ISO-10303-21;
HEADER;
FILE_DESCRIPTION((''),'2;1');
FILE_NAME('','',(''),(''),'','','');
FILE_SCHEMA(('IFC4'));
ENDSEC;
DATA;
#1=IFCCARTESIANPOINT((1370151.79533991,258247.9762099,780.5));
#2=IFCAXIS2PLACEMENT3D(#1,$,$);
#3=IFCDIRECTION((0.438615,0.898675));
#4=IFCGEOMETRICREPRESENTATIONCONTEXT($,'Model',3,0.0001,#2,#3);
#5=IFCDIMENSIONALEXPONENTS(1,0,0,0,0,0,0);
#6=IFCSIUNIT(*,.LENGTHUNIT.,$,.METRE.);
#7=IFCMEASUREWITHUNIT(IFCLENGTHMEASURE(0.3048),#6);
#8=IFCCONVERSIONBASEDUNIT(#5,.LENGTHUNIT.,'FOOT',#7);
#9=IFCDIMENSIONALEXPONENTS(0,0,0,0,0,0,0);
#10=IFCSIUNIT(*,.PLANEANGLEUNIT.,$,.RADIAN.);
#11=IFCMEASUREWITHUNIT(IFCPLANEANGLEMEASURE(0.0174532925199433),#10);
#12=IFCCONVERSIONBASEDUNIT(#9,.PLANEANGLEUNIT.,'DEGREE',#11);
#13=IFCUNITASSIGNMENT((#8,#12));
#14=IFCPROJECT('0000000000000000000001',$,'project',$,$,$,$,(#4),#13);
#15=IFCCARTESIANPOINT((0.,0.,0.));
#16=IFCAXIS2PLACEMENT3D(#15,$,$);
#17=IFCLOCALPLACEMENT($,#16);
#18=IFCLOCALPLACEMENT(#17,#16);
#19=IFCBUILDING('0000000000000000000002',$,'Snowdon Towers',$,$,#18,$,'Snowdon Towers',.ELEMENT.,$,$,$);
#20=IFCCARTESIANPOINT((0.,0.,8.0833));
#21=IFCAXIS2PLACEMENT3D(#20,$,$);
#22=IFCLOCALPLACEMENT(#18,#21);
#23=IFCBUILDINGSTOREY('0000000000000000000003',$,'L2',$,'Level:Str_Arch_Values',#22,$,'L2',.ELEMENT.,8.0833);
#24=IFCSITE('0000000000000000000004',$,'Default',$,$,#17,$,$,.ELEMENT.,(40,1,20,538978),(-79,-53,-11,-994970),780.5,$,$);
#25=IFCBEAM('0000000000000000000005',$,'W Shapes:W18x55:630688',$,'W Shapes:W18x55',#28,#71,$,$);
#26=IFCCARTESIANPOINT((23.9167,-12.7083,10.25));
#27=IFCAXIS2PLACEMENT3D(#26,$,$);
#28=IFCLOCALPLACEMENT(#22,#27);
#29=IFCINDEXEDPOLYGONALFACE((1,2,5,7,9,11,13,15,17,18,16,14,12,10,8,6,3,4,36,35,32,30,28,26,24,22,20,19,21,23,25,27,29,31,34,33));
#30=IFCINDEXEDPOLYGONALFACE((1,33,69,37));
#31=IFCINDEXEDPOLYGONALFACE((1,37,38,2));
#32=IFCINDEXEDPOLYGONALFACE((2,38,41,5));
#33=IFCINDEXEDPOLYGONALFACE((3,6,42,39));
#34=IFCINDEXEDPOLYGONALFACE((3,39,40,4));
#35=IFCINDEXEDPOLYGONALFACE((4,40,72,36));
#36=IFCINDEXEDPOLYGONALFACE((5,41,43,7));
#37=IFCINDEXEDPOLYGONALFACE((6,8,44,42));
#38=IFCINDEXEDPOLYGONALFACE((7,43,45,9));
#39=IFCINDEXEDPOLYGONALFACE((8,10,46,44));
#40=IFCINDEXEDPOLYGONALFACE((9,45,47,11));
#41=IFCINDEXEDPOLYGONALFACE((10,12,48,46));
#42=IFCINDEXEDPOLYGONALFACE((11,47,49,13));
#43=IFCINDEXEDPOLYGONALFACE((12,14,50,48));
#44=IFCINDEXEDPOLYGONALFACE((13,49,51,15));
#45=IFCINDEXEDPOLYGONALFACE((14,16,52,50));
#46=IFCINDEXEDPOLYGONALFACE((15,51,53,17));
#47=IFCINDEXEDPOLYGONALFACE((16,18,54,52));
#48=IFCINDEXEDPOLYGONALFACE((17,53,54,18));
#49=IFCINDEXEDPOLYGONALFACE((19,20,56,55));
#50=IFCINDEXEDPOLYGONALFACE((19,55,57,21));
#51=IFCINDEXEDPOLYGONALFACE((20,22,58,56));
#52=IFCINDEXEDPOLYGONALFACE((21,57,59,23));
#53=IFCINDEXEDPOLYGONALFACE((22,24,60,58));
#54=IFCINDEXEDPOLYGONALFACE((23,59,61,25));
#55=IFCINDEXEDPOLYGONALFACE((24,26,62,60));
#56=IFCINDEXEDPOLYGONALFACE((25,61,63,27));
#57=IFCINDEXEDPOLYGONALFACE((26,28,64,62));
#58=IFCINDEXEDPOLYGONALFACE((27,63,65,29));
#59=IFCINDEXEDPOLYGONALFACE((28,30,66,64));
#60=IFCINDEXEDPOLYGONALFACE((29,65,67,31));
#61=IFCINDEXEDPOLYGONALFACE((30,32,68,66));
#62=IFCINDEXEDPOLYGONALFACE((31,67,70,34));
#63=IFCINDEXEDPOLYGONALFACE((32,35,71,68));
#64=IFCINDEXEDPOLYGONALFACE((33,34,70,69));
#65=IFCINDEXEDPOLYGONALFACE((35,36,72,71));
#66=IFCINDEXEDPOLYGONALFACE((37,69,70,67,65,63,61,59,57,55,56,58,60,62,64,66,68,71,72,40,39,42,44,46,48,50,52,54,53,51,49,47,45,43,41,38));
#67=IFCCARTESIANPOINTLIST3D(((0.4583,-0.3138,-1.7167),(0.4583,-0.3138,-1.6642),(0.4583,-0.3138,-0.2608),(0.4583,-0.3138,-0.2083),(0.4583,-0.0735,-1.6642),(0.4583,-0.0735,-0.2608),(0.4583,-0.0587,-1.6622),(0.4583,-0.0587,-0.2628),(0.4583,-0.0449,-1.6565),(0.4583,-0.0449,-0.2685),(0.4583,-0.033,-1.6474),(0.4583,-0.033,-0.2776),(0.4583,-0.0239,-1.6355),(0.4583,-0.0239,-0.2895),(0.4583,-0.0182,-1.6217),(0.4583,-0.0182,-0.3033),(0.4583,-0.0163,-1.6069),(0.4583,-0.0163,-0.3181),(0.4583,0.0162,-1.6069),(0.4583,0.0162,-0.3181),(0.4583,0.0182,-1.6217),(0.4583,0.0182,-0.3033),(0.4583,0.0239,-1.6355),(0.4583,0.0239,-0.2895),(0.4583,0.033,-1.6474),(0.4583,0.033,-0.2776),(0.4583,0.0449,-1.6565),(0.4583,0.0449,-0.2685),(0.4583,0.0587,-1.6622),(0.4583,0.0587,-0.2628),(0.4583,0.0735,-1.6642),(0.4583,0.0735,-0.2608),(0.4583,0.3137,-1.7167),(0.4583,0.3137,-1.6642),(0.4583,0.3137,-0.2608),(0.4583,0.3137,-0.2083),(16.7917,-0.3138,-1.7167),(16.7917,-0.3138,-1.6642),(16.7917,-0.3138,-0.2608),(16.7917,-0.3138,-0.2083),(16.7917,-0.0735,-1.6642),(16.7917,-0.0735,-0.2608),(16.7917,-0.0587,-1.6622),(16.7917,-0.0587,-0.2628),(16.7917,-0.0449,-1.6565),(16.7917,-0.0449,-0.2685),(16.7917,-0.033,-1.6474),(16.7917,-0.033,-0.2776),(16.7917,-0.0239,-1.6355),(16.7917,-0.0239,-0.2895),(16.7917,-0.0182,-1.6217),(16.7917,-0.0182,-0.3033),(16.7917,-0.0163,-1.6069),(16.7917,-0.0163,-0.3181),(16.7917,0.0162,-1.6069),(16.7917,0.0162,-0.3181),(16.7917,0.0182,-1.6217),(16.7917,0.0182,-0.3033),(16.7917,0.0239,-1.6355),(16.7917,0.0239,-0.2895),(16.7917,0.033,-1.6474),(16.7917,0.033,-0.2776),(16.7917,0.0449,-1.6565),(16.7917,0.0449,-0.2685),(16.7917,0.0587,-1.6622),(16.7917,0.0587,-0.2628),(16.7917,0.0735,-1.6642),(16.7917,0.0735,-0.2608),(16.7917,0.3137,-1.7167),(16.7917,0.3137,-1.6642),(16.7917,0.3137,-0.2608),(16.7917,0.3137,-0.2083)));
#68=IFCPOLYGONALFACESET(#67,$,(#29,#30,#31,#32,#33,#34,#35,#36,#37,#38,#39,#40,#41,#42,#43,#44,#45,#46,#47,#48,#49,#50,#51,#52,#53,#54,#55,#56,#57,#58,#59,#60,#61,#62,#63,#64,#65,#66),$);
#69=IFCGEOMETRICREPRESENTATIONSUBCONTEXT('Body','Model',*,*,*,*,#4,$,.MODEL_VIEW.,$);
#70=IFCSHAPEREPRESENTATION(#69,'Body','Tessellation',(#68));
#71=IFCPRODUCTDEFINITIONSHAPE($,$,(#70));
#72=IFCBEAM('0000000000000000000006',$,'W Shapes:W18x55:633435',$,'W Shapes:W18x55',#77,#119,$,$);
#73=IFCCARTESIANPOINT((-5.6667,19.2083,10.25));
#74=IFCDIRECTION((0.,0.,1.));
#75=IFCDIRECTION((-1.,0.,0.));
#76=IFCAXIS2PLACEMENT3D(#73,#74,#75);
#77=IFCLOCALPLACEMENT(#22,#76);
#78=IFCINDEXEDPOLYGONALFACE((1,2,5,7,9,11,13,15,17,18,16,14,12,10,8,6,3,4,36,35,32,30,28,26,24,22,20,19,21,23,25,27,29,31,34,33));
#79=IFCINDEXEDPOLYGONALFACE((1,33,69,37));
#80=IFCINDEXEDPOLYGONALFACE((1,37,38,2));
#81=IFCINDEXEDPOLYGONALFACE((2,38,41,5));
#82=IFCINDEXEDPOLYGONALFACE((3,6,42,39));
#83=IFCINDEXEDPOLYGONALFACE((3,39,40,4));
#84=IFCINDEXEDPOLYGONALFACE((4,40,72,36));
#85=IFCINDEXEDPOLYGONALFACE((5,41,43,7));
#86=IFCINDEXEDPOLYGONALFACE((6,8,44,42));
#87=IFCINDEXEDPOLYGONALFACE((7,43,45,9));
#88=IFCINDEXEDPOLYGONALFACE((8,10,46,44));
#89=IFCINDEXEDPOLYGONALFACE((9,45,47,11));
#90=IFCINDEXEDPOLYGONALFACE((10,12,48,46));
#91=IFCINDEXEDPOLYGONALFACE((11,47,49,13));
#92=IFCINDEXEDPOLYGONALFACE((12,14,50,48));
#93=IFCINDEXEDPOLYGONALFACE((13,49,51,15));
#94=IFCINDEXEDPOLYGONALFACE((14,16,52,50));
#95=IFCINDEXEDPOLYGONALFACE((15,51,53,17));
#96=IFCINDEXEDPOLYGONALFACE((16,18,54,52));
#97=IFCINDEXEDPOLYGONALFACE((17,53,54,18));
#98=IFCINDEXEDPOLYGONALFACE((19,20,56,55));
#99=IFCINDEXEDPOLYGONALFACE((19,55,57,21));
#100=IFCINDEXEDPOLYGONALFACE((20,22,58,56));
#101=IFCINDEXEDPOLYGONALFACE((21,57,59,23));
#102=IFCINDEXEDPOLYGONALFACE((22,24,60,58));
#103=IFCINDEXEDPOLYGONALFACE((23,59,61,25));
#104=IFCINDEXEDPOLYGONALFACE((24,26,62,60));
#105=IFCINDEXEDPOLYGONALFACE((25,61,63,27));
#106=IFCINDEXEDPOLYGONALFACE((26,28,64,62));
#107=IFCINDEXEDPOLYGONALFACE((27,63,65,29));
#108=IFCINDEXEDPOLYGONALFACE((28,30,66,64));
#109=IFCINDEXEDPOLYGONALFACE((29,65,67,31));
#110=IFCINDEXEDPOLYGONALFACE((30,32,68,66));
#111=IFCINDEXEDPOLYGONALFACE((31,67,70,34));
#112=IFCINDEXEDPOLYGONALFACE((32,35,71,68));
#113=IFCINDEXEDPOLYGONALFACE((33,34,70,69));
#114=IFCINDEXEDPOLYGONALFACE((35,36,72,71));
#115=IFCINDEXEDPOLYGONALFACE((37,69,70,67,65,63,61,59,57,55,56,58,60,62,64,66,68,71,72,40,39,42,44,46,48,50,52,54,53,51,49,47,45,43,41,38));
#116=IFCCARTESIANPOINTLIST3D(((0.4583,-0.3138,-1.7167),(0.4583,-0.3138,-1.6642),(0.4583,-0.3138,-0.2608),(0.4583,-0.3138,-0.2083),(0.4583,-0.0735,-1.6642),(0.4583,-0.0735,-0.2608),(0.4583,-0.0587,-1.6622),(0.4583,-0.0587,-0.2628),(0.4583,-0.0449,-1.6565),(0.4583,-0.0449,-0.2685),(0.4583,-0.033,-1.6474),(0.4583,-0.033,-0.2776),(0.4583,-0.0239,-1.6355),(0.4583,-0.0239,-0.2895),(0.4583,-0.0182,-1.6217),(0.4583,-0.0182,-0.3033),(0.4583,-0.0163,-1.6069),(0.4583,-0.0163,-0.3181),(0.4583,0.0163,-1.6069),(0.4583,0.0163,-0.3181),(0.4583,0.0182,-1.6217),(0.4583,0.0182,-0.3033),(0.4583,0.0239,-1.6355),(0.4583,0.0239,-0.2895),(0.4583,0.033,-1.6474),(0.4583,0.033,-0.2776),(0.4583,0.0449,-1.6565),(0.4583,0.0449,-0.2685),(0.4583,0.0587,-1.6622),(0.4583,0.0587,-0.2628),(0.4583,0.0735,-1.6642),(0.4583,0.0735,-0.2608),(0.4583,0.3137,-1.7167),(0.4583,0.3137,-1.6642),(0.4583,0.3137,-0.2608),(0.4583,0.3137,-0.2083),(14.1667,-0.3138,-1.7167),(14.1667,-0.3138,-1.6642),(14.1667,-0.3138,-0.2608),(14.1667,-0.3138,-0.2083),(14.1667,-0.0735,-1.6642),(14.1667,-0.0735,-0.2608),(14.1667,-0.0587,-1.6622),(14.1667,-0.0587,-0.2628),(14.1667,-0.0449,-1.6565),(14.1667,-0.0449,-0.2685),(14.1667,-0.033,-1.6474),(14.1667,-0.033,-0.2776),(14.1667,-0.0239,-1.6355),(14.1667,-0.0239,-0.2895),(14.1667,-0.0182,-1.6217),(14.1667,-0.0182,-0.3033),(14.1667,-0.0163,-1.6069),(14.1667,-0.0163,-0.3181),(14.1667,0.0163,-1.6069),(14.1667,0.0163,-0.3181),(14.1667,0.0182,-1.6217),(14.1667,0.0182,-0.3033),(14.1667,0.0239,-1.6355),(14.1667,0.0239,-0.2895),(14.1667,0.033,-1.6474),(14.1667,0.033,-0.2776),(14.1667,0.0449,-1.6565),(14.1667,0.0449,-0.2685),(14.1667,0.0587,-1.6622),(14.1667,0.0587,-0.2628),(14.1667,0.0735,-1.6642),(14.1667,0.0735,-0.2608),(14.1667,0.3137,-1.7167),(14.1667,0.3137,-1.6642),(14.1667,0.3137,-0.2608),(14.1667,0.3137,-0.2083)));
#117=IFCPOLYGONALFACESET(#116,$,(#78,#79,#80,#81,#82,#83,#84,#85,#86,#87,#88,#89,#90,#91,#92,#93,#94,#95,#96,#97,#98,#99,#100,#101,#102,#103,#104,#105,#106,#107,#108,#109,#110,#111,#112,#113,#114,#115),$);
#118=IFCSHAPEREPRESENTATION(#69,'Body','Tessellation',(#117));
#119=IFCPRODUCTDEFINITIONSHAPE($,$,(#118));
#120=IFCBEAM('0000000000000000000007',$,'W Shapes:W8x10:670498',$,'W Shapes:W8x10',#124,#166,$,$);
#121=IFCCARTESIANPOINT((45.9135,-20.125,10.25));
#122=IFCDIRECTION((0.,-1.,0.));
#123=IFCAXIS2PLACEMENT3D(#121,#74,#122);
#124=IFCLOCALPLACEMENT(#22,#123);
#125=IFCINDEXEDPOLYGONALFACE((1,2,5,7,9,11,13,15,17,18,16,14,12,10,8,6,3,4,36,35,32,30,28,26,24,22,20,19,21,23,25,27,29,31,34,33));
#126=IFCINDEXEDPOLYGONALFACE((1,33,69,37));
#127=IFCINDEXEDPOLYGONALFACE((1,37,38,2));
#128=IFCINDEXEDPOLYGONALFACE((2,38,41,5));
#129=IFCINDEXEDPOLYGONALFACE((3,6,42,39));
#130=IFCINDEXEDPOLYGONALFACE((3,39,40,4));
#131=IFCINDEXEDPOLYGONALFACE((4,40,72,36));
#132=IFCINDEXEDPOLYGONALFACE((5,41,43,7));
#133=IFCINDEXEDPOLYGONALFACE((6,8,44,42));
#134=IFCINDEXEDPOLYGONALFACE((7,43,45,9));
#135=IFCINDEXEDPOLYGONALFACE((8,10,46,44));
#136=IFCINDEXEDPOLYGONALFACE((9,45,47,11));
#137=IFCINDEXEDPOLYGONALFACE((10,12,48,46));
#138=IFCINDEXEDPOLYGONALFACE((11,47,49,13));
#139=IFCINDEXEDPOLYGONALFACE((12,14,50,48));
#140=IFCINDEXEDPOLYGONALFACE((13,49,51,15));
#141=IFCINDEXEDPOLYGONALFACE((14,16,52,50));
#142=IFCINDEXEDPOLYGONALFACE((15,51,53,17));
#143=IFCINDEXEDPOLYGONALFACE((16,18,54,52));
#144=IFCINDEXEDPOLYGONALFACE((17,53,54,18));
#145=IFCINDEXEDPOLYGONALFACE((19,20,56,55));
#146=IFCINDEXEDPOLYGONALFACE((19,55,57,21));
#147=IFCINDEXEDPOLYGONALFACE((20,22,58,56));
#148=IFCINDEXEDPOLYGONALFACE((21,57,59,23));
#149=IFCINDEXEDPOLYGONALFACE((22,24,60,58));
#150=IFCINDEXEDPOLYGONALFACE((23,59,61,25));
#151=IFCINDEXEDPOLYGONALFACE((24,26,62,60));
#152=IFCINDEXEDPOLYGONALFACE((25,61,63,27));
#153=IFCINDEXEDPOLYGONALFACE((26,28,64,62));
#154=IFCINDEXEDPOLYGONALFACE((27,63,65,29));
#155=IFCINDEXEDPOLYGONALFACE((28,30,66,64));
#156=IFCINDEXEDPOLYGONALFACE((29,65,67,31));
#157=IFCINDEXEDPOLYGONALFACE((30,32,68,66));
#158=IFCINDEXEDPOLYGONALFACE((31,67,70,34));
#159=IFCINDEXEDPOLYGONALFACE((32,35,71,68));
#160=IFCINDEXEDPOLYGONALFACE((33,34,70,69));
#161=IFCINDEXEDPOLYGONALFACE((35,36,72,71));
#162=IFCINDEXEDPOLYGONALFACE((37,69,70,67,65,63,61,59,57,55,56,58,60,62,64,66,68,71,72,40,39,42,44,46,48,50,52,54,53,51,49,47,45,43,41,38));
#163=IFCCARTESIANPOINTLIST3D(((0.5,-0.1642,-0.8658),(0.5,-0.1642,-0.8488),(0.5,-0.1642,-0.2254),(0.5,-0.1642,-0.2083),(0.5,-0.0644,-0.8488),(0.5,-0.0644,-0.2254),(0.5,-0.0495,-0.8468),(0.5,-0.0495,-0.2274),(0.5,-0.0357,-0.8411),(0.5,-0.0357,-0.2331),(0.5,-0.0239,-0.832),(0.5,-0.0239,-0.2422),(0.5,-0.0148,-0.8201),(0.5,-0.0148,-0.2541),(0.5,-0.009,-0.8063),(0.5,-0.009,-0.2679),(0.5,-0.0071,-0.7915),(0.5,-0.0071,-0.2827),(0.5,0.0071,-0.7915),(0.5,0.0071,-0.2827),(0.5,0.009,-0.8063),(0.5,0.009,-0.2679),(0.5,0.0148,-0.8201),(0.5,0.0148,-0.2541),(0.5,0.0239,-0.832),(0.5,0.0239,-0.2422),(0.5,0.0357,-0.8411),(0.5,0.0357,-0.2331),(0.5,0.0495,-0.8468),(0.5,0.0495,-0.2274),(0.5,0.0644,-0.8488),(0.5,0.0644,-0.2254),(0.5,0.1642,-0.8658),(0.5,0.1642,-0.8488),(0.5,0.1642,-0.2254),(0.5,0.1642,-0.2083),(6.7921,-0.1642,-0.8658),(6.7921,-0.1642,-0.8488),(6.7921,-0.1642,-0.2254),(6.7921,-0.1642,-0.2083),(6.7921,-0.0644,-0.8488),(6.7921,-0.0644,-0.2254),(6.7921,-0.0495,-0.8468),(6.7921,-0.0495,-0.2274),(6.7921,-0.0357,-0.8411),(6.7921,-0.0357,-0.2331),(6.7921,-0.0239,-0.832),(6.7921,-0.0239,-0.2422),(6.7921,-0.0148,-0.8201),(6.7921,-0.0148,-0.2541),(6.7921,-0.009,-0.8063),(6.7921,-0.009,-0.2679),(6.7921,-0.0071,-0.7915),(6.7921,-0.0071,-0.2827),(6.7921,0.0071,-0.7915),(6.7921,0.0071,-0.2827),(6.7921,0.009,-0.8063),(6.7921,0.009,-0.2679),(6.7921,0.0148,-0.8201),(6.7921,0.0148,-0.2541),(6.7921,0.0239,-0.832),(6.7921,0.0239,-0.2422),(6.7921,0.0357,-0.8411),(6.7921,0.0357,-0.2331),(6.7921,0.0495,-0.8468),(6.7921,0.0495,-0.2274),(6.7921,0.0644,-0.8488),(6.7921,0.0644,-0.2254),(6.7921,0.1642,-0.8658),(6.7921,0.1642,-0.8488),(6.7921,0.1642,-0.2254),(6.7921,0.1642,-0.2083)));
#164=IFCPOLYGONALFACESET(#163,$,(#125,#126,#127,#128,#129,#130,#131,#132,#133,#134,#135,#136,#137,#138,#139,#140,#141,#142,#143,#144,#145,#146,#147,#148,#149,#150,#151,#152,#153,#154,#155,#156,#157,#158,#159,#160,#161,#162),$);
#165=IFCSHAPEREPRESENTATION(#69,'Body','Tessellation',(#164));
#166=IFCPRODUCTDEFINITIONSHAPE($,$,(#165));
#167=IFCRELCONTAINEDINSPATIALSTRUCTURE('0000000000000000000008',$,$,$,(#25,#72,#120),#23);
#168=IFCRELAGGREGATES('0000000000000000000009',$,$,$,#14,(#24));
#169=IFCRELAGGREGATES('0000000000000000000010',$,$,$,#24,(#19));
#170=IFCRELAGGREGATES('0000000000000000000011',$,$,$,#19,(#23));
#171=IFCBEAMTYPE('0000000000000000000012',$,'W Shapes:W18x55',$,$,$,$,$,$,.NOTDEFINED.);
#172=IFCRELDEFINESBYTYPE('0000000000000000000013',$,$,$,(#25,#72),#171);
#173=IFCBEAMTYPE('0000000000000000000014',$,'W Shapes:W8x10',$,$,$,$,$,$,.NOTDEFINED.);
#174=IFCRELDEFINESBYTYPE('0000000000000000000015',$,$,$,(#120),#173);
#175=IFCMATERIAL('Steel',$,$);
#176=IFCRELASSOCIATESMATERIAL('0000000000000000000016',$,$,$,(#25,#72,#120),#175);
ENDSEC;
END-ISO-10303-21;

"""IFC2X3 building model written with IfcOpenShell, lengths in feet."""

from ifc_helpers import new_model, entity, si_unit, converted_unit, direction, frame, frame_2d, origin, place, context, subcontext, project, spatial, i_section, extrude, material, type_object, element, save


model = new_model("IFC2X3")

# Units and contexts
model_context = context("Model", 3, precision=0.0001, world=frame((1370151.79533991, 258247.9762099, 780.5)), true_north=direction((0.438615, 0.898675)))
body_context = subcontext(model_context, "Body", "Model", "MODEL_VIEW")
ifc_project = project(units=[converted_unit("LENGTHUNIT", "FOOT", entity("IfcLengthMeasure", 0.3048), si_unit("LENGTHUNIT", "METRE"), dimensions=[1, 0, 0, 0, 0, 0, 0]), converted_unit("PLANEANGLEUNIT", "DEGREE", entity("IfcPlaneAngleMeasure", 0.0174532925199433), si_unit("PLANEANGLEUNIT", "RADIAN"), dimensions=[0, 0, 0, 0, 0, 0, 0])], contexts=[model_context])

# Site, building, storey
site_placement = place(None, origin())
site = spatial("IfcSite", under=ifc_project, at=site_placement, Name="Default", CompositionType="ELEMENT", RefLatitude=(40, 1, 20, 538978), RefLongitude=(-79, -53, -11, -994970), RefElevation=780.5)
building_placement = place(site_placement, origin())
building = spatial("IfcBuilding", under=site, at=building_placement, Name="Snowdon Towers", LongName="Snowdon Towers", CompositionType="ELEMENT")
storey_placement = place(building_placement, frame((0.0, 0.0, 8.0833)))
storey = spatial("IfcBuildingStorey", under=building, at=storey_placement, Name="L2", ObjectType="Level:Str_Arch_Values", LongName="L2", CompositionType="ELEMENT", Elevation=8.0833)

# Beams
ifc_material = material(Name="Steel")
beam_type_1 = type_object("IfcBeamType", Name="W Shapes:W18x55", PredefinedType="NOTDEFINED")
beam_1_placement = place(storey_placement, frame((23.9167, -12.7083, 10.25)))
element("IfcBeam", 1, at=beam_1_placement, inside=storey, type_object=beam_type_1, material=ifc_material, Name="W Shapes:W18x55:630688", ObjectType="W Shapes:W18x55", context=body_context, shape_type="SweptSolid", body=[
    extrude(i_section(OverallWidth=0.6275, OverallDepth=1.5083, WebThickness=0.0325, FlangeThickness=0.0525, FilletRadius=0.0573, at=frame_2d((0.0, 0.0), x_axis=(0.0, 1.0))), frame((0.4583, 0.0, -0.9625), z_axis=(1.0, 0.0, 0.0), x_axis=(0.0, 0.0, -1.0)), (0.0, 0.0, 1.0), 16.3333),
])
beam_2_placement = place(storey_placement, frame((-5.6667, 19.2083, 10.25), z_axis=(0.0, 0.0, 1.0), x_axis=(-1.0, 0.0, 0.0)))
element("IfcBeam", 2, at=beam_2_placement, inside=storey, type_object=beam_type_1, material=ifc_material, Name="W Shapes:W18x55:633435", ObjectType="W Shapes:W18x55", context=body_context, shape_type="SweptSolid", body=[
    extrude(i_section(OverallWidth=0.6275, OverallDepth=1.5083, WebThickness=0.0325, FlangeThickness=0.0525, FilletRadius=0.0573, at=frame_2d((0.0, 0.0), x_axis=(0.0, 1.0))), frame((0.4583, 0.0, -0.9625), z_axis=(1.0, 0.0, 0.0), x_axis=(0.0, 0.0, -1.0)), (0.0, 0.0, 1.0), 13.7083),
])
beam_type_2 = type_object("IfcBeamType", Name="W Shapes:W8x10", PredefinedType="NOTDEFINED")
beam_3_placement = place(storey_placement, frame((45.9135, -20.125, 10.25), z_axis=(0.0, 0.0, 1.0), x_axis=(0.0, -1.0, 0.0)))
element("IfcBeam", 3, at=beam_3_placement, inside=storey, type_object=beam_type_2, material=ifc_material, Name="W Shapes:W8x10:670498", ObjectType="W Shapes:W8x10", context=body_context, shape_type="SweptSolid", body=[
    extrude(i_section(OverallWidth=0.3283, OverallDepth=0.6575, WebThickness=0.0142, FlangeThickness=0.0171, FilletRadius=0.0573, at=frame_2d((0.0, 0.0), x_axis=(0.0, 1.0))), frame((0.5, 0.0, -0.5371), z_axis=(1.0, 0.0, 0.0), x_axis=(0.0, 0.0, -1.0)), (0.0, 0.0, 1.0), 6.2921),
])

save(model, "model.ifc")
